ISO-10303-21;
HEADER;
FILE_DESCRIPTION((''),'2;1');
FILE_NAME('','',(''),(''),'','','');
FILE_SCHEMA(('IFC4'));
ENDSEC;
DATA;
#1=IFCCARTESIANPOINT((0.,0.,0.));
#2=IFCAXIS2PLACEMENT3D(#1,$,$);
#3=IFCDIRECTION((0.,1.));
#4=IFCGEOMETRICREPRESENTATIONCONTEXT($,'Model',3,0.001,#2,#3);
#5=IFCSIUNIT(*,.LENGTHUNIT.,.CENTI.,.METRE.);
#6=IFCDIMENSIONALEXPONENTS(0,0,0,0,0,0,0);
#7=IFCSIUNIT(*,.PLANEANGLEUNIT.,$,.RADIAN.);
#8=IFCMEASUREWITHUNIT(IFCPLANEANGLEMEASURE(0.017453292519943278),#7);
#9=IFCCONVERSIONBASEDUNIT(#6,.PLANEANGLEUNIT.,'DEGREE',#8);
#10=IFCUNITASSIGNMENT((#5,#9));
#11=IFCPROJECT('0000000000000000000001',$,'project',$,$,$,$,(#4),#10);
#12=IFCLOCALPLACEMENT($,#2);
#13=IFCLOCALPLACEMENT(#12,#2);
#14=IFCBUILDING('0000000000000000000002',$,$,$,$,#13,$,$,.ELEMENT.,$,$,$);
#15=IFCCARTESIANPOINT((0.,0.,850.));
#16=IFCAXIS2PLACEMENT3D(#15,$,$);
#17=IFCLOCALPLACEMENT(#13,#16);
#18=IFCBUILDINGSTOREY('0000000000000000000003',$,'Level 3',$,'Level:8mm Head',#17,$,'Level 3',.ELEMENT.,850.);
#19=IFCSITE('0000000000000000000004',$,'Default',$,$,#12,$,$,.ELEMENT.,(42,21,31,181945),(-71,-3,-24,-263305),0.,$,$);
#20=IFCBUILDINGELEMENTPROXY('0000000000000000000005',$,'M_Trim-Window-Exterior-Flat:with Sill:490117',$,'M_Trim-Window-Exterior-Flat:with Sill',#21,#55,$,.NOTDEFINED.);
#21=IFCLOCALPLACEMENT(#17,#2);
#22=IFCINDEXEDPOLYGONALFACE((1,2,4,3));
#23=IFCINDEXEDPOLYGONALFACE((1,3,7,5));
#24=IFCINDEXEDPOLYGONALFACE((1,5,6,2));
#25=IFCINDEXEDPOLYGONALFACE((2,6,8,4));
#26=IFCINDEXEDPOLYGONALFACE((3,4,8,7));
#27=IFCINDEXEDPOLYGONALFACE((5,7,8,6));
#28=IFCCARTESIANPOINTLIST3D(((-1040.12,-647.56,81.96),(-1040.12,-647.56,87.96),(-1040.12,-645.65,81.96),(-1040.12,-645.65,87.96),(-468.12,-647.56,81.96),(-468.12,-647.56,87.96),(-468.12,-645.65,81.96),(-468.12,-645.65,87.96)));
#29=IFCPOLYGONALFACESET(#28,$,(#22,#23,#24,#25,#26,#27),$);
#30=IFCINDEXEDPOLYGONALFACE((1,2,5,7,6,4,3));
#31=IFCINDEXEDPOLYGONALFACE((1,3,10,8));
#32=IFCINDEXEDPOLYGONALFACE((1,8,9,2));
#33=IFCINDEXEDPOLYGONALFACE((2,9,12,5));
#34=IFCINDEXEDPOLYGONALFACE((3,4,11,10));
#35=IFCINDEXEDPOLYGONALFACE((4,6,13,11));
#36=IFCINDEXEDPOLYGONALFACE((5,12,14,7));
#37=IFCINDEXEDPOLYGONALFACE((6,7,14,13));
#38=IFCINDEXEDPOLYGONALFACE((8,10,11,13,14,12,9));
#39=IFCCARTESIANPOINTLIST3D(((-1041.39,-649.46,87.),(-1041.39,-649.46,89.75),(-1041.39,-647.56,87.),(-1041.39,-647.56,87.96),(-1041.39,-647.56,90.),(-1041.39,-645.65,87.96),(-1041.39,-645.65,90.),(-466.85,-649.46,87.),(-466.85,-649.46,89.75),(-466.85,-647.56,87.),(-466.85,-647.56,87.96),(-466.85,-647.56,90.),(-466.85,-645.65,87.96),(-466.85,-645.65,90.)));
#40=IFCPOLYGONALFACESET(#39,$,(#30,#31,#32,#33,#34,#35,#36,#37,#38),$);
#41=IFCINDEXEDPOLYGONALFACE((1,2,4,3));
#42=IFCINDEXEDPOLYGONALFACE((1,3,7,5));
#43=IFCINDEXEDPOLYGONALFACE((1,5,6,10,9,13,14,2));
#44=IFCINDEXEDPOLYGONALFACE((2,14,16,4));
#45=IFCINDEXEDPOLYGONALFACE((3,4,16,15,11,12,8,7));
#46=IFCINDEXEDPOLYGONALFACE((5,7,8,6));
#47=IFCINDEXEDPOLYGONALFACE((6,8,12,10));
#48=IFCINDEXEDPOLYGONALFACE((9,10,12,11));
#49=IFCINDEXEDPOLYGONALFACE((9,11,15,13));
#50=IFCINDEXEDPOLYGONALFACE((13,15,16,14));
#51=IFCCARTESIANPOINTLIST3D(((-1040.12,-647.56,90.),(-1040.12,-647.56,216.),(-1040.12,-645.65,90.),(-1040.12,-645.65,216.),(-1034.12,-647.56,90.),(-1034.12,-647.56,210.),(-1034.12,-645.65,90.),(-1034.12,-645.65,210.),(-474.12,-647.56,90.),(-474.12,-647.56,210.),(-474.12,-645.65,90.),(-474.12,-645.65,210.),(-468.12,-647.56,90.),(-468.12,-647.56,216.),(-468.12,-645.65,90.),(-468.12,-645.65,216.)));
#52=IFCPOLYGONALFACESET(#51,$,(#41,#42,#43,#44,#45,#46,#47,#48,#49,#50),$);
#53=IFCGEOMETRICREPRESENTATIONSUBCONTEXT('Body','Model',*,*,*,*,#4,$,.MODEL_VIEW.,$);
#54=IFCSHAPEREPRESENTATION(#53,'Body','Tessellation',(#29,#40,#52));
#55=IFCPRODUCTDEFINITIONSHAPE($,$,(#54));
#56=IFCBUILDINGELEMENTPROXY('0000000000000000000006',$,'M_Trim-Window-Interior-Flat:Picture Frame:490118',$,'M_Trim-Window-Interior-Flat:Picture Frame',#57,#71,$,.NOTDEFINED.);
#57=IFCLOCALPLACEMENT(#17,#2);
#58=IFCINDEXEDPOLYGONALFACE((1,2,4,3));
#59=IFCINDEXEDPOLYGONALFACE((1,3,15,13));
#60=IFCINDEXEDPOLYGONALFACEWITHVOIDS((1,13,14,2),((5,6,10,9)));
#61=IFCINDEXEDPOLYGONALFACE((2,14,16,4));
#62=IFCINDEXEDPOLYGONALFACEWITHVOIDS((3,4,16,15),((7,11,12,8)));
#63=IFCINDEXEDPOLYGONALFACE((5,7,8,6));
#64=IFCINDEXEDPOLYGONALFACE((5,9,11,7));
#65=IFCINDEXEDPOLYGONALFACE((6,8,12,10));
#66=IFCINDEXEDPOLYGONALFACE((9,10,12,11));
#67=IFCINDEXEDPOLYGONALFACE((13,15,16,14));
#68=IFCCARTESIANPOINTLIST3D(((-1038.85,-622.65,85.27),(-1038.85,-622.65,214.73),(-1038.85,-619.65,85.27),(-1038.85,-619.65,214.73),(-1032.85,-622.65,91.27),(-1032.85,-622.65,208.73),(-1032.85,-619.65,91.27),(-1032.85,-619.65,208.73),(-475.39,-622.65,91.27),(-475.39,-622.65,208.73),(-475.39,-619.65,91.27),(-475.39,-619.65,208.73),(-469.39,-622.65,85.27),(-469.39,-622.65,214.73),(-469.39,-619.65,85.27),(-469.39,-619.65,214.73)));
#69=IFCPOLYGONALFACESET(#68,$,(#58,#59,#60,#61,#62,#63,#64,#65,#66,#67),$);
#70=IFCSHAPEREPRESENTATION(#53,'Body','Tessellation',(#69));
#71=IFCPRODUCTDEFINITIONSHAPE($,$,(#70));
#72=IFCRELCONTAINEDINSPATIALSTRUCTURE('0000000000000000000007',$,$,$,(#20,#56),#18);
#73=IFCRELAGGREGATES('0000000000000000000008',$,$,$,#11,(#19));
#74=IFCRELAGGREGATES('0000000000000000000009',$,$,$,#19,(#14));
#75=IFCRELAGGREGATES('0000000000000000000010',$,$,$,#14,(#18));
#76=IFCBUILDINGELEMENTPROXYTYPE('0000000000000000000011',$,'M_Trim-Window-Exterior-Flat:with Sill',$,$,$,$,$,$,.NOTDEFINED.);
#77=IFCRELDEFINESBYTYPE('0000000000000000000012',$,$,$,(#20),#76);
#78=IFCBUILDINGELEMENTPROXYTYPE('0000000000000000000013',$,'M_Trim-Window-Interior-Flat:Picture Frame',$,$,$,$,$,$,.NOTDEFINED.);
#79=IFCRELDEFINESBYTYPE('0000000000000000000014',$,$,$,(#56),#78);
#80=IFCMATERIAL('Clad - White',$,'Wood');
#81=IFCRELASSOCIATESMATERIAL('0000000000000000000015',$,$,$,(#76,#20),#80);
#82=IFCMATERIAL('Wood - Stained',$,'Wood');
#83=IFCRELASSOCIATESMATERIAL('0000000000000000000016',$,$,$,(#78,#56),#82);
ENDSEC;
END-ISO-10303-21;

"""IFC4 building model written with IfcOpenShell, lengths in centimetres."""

from ifc_helpers import new_model, entity, si_unit, converted_unit, direction, frame, origin, place, context, subcontext, project, spatial, indexed_curve, outline, extrude, source, transform, mapped, material, type_object, type_shapes, element, save


model = new_model("IFC4")

# Units and contexts
model_context = context("Model", 3, precision=0.001, world=origin(), true_north=direction((0.0, 1.0)))
body_context = subcontext(model_context, "Body", "Model", "MODEL_VIEW")
ifc_project = project(units=[si_unit("LENGTHUNIT", "METRE", prefix="CENTI"), converted_unit("PLANEANGLEUNIT", "DEGREE", entity("IfcPlaneAngleMeasure", 0.017453292519943278), si_unit("PLANEANGLEUNIT", "RADIAN"), dimensions=[0, 0, 0, 0, 0, 0, 0])], contexts=[model_context])

# Site, building, storey
site_placement = place(None, origin())
site = spatial("IfcSite", under=ifc_project, at=site_placement, Name="Default", CompositionType="ELEMENT", RefLatitude=(42, 21, 31, 181945), RefLongitude=(-71, -3, -24, -263305), RefElevation=0.0)
building_placement = place(site_placement, origin())
building = spatial("IfcBuilding", under=site, at=building_placement, CompositionType="ELEMENT")
storey_placement = place(building_placement, frame((0.0, 0.0, 850.0)))
storey = spatial("IfcBuildingStorey", under=building, at=storey_placement, Name="Level 3", ObjectType="Level:8mm Head", LongName="Level 3", CompositionType="ELEMENT", Elevation=850.0)

# Building element proxies
ifc_material_1 = material(Name="Clad - White", Category="Wood")
ifc_material_2 = material(Name="Wood - Stained", Category="Wood")
building_element_proxy_type_1 = type_object("IfcBuildingElementProxyType", Name="M_Trim-Window-Exterior-Flat:with Sill", PredefinedType="NOTDEFINED", material=ifc_material_1)
shared_shape_1 = source(origin(), body_context, "Body", "SweptSolid", [
    extrude(outline(indexed_curve([(-286.0, -3.0), (286.0, -3.0), (286.0, 3.0), (-286.0, 3.0), (-286.0, -3.0)], self_intersect=False)), frame((0.0, -125.04, 0.0), z_axis=(0.0, 0.0, 1.0), x_axis=(-1.0, 0.0, 0.0)), (0.0, 0.0, 1.0), 1.9),
    extrude(outline(indexed_curve([(-1.9, -1.52), (0.0, -1.52), (0.0, -0.57), (1.9, -0.57), (1.9, 1.48), (0.0, 1.48), (-1.9, 1.23), (-1.9, -1.52)], self_intersect=False)), frame((-287.27, -121.48, 1.9), z_axis=(1.0, 0.0, 0.0), x_axis=(0.0, 0.0, -1.0)), (0.0, 0.0, 1.0), 574.54),
    extrude(outline(indexed_curve([(-64.5, -286.0), (61.5, -286.0), (61.5, -280.0), (-58.5, -280.0), (-58.5, 280.0), (61.5, 280.0), (61.5, 286.0), (-64.5, 286.0), (-64.5, -286.0)], self_intersect=False)), frame((0.0, -58.5, 0.0), z_axis=(0.0, 0.0, 1.0), x_axis=(0.0, -1.0, 0.0)), (0.0, 0.0, 1.0), 1.9),
])
type_shapes(building_element_proxy_type_1, [shared_shape_1])
proxy_1_placement = place(storey_placement, frame((-754.12, -645.65, 210.0), z_axis=(0.0, -1.0, 0.0), x_axis=(1.0, 0.0, 0.0)))
element("IfcBuildingElementProxy", 1, at=proxy_1_placement, inside=storey, type_object=building_element_proxy_type_1, material=ifc_material_1, Name="M_Trim-Window-Exterior-Flat:with Sill:490117", ObjectType="M_Trim-Window-Exterior-Flat:with Sill", PredefinedType="NOTDEFINED", context=body_context, shape_type="MappedRepresentation", body=[
    mapped(shared_shape_1, transform((0.0, 0.0, 0.0), scale=1.0)),
])
building_element_proxy_type_2 = type_object("IfcBuildingElementProxyType", Name="M_Trim-Window-Interior-Flat:Picture Frame", PredefinedType="NOTDEFINED", material=ifc_material_2)
shared_shape_2 = source(origin(), body_context, "Body", "SweptSolid", [
    extrude(outline(indexed_curve([(-284.73, -64.73), (284.73, -64.73), (284.73, 64.73), (-284.73, 64.73), (-284.73, -64.73)], self_intersect=False), holes=[indexed_curve([(-278.73, -58.73), (-278.73, 58.73), (278.73, 58.73), (278.73, -58.73), (-278.73, -58.73)], self_intersect=False)]), frame((0.0, -60.0, 0.0), z_axis=(0.0, 0.0, 1.0), x_axis=(-1.0, 0.0, 0.0)), (0.0, 0.0, 1.0), 3.0),
])
type_shapes(building_element_proxy_type_2, [shared_shape_2])
proxy_2_placement = place(storey_placement, frame((-754.12, -622.65, 210.0), z_axis=(0.0, 1.0, 0.0), x_axis=(-1.0, 0.0, 0.0)))
element("IfcBuildingElementProxy", 2, at=proxy_2_placement, inside=storey, type_object=building_element_proxy_type_2, material=ifc_material_2, Name="M_Trim-Window-Interior-Flat:Picture Frame:490118", ObjectType="M_Trim-Window-Interior-Flat:Picture Frame", PredefinedType="NOTDEFINED", context=body_context, shape_type="MappedRepresentation", body=[
    mapped(shared_shape_2, transform((0.0, 0.0, 0.0), scale=1.0)),
])

save(model, "model.ifc")
